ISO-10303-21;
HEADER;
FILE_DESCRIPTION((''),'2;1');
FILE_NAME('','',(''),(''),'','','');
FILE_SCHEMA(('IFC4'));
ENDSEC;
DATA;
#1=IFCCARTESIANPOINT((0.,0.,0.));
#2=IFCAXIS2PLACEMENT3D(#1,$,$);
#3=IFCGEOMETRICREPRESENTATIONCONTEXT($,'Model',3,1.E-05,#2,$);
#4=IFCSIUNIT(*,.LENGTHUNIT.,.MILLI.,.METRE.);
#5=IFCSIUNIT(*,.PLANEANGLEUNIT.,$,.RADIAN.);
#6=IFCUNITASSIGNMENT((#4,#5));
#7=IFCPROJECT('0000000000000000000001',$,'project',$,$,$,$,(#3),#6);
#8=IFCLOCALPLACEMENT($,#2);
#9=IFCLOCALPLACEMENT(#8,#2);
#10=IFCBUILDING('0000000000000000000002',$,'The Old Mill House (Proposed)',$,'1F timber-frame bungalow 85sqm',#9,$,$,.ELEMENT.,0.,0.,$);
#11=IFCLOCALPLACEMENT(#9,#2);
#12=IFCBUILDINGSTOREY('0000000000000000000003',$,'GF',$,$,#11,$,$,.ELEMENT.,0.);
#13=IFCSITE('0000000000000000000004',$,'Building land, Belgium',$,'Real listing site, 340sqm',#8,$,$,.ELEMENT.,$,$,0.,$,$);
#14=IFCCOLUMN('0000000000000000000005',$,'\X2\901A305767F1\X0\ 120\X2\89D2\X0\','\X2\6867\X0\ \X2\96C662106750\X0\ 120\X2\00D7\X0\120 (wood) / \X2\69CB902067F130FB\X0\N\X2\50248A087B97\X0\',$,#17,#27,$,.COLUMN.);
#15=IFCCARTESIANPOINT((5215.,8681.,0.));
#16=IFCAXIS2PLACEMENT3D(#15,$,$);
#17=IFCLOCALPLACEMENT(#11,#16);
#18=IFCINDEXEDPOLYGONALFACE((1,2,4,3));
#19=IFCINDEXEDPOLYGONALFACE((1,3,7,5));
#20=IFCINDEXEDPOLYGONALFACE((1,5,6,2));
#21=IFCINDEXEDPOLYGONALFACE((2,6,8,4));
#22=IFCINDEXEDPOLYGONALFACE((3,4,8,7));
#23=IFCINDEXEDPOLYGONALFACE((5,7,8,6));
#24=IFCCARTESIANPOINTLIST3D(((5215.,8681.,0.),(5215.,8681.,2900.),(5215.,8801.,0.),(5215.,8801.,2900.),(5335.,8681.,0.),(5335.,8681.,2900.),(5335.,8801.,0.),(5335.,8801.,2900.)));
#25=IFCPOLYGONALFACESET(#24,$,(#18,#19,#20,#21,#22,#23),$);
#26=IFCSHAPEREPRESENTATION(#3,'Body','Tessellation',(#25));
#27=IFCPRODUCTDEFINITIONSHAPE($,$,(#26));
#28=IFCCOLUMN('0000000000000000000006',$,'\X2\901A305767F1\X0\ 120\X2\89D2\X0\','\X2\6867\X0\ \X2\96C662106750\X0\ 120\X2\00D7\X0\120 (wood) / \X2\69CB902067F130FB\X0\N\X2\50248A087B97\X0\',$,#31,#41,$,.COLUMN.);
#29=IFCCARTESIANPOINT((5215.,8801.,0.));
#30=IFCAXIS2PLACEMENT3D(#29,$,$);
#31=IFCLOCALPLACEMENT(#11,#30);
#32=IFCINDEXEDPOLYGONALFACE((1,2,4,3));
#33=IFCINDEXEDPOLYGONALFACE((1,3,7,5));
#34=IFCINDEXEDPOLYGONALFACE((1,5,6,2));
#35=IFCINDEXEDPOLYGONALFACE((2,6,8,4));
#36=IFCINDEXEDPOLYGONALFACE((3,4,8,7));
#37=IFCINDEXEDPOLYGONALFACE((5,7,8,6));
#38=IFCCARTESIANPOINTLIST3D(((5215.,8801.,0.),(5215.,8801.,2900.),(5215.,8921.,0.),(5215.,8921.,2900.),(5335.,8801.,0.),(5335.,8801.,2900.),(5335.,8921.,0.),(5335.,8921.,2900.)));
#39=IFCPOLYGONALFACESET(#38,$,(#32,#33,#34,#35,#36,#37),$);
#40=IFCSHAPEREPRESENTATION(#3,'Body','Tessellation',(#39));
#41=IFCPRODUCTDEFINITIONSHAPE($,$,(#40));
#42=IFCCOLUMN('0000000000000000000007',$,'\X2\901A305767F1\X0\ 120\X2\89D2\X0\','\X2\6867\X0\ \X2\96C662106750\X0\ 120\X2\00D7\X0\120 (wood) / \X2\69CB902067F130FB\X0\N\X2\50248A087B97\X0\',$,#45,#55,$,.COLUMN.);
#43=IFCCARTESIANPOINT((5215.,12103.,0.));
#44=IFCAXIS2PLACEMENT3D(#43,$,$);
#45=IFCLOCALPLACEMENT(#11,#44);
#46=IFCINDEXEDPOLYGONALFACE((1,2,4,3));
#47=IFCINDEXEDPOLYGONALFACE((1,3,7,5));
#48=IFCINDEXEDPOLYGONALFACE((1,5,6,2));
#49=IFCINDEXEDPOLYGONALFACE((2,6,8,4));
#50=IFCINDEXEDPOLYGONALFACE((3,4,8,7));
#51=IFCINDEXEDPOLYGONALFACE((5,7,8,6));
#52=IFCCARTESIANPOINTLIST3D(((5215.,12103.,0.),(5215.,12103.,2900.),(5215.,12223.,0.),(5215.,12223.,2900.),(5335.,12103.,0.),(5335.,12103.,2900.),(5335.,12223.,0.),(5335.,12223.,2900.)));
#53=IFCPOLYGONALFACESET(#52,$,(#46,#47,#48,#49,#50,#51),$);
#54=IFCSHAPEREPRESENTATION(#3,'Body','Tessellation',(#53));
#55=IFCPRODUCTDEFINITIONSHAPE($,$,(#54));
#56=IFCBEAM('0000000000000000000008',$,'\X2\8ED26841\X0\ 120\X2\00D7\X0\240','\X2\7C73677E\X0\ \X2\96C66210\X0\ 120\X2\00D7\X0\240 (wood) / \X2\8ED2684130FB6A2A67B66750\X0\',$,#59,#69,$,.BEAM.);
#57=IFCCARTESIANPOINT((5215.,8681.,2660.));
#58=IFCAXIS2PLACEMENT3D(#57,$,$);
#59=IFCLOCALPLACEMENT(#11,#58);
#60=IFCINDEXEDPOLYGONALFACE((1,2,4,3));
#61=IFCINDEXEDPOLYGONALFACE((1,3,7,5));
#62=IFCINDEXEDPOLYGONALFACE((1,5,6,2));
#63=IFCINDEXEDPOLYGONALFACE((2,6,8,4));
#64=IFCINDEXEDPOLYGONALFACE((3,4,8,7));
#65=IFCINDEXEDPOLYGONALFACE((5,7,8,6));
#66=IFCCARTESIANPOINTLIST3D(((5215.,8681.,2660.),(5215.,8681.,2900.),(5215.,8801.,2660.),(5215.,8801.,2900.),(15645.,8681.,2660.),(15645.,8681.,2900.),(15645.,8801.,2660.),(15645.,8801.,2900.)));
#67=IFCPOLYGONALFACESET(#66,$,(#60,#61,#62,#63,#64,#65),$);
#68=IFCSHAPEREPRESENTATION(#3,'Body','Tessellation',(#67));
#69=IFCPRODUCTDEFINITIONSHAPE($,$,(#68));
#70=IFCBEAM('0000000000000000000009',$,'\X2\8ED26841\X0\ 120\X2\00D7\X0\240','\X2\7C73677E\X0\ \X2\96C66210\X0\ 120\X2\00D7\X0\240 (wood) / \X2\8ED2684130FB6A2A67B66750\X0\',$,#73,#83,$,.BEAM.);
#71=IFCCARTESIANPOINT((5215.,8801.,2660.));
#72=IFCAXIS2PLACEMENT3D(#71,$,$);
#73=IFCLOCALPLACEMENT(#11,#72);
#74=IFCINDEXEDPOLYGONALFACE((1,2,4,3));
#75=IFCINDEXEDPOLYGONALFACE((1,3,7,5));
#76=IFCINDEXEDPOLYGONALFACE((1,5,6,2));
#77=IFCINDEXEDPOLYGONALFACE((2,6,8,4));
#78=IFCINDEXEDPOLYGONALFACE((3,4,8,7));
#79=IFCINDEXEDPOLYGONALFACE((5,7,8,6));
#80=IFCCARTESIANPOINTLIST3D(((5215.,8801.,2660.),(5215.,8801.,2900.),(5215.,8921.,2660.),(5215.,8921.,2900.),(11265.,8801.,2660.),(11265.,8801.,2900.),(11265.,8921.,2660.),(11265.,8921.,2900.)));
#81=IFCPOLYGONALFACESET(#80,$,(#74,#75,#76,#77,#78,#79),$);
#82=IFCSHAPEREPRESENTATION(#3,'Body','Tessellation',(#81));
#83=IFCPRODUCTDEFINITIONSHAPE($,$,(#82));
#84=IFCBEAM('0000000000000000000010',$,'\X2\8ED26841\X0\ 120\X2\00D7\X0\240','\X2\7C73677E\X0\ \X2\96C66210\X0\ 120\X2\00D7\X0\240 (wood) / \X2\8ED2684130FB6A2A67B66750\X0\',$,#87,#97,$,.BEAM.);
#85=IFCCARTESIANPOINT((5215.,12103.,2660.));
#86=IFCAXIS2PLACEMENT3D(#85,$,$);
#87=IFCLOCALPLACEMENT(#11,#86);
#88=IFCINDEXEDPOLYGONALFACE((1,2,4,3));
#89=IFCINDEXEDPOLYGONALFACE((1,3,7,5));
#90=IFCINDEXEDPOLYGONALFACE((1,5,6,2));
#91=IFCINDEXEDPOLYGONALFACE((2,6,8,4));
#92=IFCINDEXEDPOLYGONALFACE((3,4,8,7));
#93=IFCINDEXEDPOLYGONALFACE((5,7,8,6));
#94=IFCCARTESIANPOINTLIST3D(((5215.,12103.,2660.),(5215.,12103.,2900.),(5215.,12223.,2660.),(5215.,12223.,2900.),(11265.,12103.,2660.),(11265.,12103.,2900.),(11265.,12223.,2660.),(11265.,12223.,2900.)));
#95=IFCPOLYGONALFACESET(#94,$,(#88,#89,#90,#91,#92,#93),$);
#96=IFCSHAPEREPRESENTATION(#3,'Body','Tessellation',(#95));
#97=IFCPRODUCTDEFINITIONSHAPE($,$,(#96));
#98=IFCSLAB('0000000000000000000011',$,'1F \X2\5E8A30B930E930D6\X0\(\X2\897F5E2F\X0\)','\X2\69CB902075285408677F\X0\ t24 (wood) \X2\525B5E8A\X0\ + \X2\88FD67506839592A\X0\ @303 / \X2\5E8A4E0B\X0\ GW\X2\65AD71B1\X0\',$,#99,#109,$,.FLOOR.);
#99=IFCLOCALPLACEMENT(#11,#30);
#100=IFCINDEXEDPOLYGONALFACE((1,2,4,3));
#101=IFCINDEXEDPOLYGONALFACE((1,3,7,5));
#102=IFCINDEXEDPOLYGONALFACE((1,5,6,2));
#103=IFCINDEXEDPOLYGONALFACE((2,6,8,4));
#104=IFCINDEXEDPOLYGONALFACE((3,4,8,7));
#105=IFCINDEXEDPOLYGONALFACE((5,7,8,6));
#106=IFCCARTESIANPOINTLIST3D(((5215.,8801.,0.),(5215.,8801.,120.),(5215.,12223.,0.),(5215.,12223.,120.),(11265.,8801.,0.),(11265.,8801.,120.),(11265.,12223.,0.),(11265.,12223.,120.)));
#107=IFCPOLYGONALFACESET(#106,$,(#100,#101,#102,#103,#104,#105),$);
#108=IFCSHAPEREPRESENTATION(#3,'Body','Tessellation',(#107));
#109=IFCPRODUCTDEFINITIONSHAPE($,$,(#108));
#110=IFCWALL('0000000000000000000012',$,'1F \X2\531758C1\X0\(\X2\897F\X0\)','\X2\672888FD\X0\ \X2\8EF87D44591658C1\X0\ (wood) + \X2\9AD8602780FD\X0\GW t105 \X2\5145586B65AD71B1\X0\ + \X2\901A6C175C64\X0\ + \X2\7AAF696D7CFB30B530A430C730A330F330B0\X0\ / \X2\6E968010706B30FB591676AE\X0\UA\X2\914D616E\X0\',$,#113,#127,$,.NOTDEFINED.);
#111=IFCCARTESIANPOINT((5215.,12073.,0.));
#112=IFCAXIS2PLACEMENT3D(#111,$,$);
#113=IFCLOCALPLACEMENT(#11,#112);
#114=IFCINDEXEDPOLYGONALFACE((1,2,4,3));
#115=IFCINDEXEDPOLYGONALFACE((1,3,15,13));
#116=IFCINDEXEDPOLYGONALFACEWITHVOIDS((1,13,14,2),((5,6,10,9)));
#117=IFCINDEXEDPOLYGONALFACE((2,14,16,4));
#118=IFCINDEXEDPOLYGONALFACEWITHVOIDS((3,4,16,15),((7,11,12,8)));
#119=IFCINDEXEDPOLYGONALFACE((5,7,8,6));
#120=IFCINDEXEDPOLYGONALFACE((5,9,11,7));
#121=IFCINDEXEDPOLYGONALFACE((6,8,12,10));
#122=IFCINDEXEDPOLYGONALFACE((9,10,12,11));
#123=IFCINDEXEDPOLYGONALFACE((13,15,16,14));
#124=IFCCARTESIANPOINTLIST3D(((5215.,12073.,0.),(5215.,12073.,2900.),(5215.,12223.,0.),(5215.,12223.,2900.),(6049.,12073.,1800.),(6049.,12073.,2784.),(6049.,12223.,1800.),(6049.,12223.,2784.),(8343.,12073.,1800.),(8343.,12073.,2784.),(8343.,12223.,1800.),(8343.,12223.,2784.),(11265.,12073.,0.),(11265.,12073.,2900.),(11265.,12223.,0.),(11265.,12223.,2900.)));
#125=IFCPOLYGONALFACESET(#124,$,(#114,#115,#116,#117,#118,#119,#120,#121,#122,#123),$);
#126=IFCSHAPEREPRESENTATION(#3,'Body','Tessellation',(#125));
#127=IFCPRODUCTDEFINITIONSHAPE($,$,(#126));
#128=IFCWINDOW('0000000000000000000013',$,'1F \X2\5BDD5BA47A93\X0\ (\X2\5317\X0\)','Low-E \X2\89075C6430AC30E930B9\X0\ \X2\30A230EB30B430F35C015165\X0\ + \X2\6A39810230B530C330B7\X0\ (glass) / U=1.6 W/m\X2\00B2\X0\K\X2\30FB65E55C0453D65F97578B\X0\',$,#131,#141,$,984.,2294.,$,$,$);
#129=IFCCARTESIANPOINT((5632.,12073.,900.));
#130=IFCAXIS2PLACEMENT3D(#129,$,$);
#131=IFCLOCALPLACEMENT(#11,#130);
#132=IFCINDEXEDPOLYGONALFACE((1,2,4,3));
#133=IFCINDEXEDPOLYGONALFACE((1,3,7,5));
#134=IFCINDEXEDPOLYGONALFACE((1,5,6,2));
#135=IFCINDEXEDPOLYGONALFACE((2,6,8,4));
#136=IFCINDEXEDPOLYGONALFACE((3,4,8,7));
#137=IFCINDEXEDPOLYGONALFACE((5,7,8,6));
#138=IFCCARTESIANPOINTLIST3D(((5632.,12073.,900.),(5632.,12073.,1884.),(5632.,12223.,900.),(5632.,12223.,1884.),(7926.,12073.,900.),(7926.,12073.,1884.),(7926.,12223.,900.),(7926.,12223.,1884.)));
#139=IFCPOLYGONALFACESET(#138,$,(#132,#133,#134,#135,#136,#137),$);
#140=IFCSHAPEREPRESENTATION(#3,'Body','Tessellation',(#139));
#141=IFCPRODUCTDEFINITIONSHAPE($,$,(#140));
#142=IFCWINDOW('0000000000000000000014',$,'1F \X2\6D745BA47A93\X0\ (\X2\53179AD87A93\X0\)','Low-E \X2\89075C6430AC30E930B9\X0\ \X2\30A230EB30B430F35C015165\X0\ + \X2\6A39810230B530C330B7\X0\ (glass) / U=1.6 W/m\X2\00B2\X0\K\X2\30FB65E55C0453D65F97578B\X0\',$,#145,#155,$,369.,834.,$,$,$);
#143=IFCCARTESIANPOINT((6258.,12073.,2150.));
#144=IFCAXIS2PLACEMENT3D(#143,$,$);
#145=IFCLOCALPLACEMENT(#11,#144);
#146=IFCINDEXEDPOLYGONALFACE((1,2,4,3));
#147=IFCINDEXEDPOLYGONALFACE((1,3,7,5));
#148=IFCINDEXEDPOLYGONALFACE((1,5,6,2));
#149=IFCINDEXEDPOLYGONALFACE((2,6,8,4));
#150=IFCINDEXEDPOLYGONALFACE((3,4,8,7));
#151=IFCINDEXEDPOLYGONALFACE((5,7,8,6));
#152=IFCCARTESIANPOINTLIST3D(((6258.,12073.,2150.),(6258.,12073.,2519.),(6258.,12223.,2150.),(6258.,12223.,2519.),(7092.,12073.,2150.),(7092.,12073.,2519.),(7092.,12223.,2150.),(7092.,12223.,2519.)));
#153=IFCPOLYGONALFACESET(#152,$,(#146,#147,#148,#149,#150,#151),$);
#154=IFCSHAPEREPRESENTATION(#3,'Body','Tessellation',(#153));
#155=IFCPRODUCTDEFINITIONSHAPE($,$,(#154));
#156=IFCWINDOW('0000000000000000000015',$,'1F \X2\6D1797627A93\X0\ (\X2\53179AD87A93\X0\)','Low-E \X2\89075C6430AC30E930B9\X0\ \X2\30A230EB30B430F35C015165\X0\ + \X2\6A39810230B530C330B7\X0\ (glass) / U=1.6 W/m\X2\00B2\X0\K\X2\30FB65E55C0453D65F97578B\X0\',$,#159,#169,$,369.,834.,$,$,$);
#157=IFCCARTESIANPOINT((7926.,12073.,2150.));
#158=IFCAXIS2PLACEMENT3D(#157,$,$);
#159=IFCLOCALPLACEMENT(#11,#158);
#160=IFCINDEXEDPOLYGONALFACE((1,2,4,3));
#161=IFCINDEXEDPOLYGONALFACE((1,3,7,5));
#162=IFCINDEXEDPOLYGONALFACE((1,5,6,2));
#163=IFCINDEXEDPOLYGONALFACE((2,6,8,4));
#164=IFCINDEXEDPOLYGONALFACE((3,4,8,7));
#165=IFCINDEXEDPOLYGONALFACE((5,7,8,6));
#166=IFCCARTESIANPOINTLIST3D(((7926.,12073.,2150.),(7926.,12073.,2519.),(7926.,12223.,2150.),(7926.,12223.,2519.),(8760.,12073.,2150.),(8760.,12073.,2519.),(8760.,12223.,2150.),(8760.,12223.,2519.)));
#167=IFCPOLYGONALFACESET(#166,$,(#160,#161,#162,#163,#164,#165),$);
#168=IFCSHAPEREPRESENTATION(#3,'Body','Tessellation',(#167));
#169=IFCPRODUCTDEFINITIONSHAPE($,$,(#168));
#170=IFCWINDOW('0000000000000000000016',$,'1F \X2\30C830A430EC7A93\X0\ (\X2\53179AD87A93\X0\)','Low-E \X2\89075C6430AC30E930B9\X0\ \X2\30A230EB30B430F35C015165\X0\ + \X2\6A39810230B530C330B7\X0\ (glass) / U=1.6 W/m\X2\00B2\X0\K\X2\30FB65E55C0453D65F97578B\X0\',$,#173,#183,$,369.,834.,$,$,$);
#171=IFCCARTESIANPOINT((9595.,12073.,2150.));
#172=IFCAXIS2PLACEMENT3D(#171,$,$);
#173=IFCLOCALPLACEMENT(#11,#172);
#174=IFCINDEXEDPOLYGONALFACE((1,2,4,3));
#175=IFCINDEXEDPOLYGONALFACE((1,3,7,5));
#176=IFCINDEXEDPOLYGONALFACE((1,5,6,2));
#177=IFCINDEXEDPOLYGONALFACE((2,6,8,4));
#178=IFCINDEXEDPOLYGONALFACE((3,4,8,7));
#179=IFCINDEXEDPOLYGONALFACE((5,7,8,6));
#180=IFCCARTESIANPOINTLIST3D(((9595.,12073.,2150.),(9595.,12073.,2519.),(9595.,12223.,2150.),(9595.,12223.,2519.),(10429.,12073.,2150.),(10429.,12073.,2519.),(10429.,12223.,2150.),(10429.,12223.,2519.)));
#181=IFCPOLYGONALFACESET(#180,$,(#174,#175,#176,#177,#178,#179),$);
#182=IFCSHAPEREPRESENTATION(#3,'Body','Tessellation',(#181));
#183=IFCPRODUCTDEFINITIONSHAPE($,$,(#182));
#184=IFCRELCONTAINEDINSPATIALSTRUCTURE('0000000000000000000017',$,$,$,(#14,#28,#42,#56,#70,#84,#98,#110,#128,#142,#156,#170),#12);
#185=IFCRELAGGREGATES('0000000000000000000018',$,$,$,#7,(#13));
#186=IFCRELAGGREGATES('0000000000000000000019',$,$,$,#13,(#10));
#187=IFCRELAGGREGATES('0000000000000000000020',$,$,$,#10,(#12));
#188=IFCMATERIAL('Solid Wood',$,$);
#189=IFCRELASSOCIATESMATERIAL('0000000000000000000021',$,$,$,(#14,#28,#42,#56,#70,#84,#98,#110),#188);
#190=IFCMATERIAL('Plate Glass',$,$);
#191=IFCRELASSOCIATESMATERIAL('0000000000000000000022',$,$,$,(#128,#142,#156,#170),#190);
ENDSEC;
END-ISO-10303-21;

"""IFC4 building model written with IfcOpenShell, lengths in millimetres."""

from ifc_helpers import new_model, si_unit, frame, frame_2d, origin, place, context, project, spatial, rectangle, extrude, material, element, fill, save


model = new_model("IFC4")

# Units and contexts
model_context = context("Model", 3, precision=1e-05, world=origin())
ifc_project = project(units=[si_unit("LENGTHUNIT", "METRE", prefix="MILLI"), si_unit("PLANEANGLEUNIT", "RADIAN")], contexts=[model_context])

# Site, building, storey
site_placement = place(None, origin())
site = spatial("IfcSite", under=ifc_project, at=site_placement, Name="Building land, Belgium", ObjectType="Real listing site, 340sqm", CompositionType="ELEMENT", RefElevation=0.0)
building_placement = place(site_placement, origin())
building = spatial("IfcBuilding", under=site, at=building_placement, Name="The Old Mill House (Proposed)", ObjectType="1F timber-frame bungalow 85sqm", CompositionType="ELEMENT", ElevationOfRefHeight=0.0, ElevationOfTerrain=0.0)
storey_placement = place(building_placement, origin())
storey = spatial("IfcBuildingStorey", under=building, at=storey_placement, Name="GF", CompositionType="ELEMENT", Elevation=0.0)

# Columns
ifc_material_1 = material(Name="Solid Wood")
column_1_placement = place(storey_placement, frame((5215.0, 8681.0, 0.0)))
element("IfcColumn", 1, at=column_1_placement, inside=storey, material=ifc_material_1, Name="通し柱 120角", Description="桧 集成材 120×120 (wood) / 構造柱・N値計算", PredefinedType="COLUMN", context=model_context, shape_type="SweptSolid", body=[
    extrude(rectangle(XDim=120.0, YDim=120.0, at=frame_2d((60.0, 60.0))), frame((5215.0, 8681.0, 0.0)), (0.0, 0.0, 1.0), 2900.0),
])
column_2_placement = place(storey_placement, frame((5215.0, 8801.0, 0.0)))
element("IfcColumn", 2, at=column_2_placement, inside=storey, material=ifc_material_1, Name="通し柱 120角", Description="桧 集成材 120×120 (wood) / 構造柱・N値計算", PredefinedType="COLUMN", context=model_context, shape_type="SweptSolid", body=[
    extrude(rectangle(XDim=120.0, YDim=120.0, at=frame_2d((60.0, 60.0))), frame((5215.0, 8801.0, 0.0)), (0.0, 0.0, 1.0), 2900.0),
])
column_3_placement = place(storey_placement, frame((5215.0, 12103.0, 0.0)))
element("IfcColumn", 3, at=column_3_placement, inside=storey, material=ifc_material_1, Name="通し柱 120角", Description="桧 集成材 120×120 (wood) / 構造柱・N値計算", PredefinedType="COLUMN", context=model_context, shape_type="SweptSolid", body=[
    extrude(rectangle(XDim=120.0, YDim=120.0, at=frame_2d((60.0, 60.0))), frame((5215.0, 12103.0, 0.0)), (0.0, 0.0, 1.0), 2900.0),
])

# Beams
beam_1_placement = place(storey_placement, frame((5215.0, 8681.0, 2660.0)))
element("IfcBeam", 4, at=beam_1_placement, inside=storey, material=ifc_material_1, Name="軒桁 120×240", Description="米松 集成 120×240 (wood) / 軒桁・横架材", PredefinedType="BEAM", context=model_context, shape_type="SweptSolid", body=[
    extrude(rectangle(XDim=10430.0, YDim=120.0, at=frame_2d((5215.0, 60.0))), frame((5215.0, 8681.0, 2660.0)), (0.0, 0.0, 1.0), 240.0),
])
beam_2_placement = place(storey_placement, frame((5215.0, 8801.0, 2660.0)))
element("IfcBeam", 5, at=beam_2_placement, inside=storey, material=ifc_material_1, Name="軒桁 120×240", Description="米松 集成 120×240 (wood) / 軒桁・横架材", PredefinedType="BEAM", context=model_context, shape_type="SweptSolid", body=[
    extrude(rectangle(XDim=6050.0, YDim=120.0, at=frame_2d((3025.0, 60.0))), frame((5215.0, 8801.0, 2660.0)), (0.0, 0.0, 1.0), 240.0),
])
beam_3_placement = place(storey_placement, frame((5215.0, 12103.0, 2660.0)))
element("IfcBeam", 6, at=beam_3_placement, inside=storey, material=ifc_material_1, Name="軒桁 120×240", Description="米松 集成 120×240 (wood) / 軒桁・横架材", PredefinedType="BEAM", context=model_context, shape_type="SweptSolid", body=[
    extrude(rectangle(XDim=6050.0, YDim=120.0, at=frame_2d((3025.0, 60.0))), frame((5215.0, 12103.0, 2660.0)), (0.0, 0.0, 1.0), 240.0),
])

# Slab
slab_placement = place(storey_placement, frame((5215.0, 8801.0, 0.0)))
element("IfcSlab", 7, at=slab_placement, inside=storey, material=ifc_material_1, Name="1F 床スラブ(西帯)", Description="構造用合板 t24 (wood) 剛床 + 製材根太 @303 / 床下 GW断熱", PredefinedType="FLOOR", context=model_context, shape_type="SweptSolid", body=[
    extrude(rectangle(XDim=6050.0, YDim=3422.0, at=frame_2d((3025.0, 1711.0))), frame((5215.0, 8801.0, 0.0)), (0.0, 0.0, 1.0), 120.0),
])

# Wall, openings, windows
wall_1_placement = place(storey_placement, frame((5215.0, 12073.0, 0.0)))
wall_1 = element("IfcWall", 8, at=wall_1_placement, inside=storey, material=ifc_material_1, Name="1F 北壁(西)", Description="木製 軸組外壁 (wood) + 高性能GW t105 充填断熱 + 通気層 + 窯業系サイディング / 準耐火・外皮UA配慮", PredefinedType="NOTDEFINED", context=model_context, shape_type="SweptSolid", body=[
    extrude(rectangle(XDim=6050.0, YDim=150.0, at=frame_2d((3025.0, 75.0))), frame((5215.0, 12073.0, 0.0)), (0.0, 0.0, 1.0), 2900.0),
])
opening_1_placement = place(storey_placement, frame((5632.0, 12073.0, 900.0)))
opening_1 = element("IfcOpeningElement", 9, at=opening_1_placement, cuts=wall_1, PredefinedType="NOTDEFINED", context=model_context, shape_type="SweptSolid", body=[
    extrude(rectangle(XDim=2294.0, YDim=150.0, at=frame_2d((1147.0, 75.0))), frame((5632.0, 12073.0, 900.0)), (0.0, 0.0, 1.0), 984.0),
])
opening_2_placement = place(storey_placement, frame((6258.0, 12073.0, 2150.0)))
opening_2 = element("IfcOpeningElement", 10, at=opening_2_placement, cuts=wall_1, PredefinedType="NOTDEFINED", context=model_context, shape_type="SweptSolid", body=[
    extrude(rectangle(XDim=834.0, YDim=150.0, at=frame_2d((417.0, 75.0))), frame((6258.0, 12073.0, 2150.0)), (0.0, 0.0, 1.0), 369.0),
])
opening_3_placement = place(storey_placement, frame((7926.0, 12073.0, 2150.0)))
opening_3 = element("IfcOpeningElement", 11, at=opening_3_placement, cuts=wall_1, PredefinedType="NOTDEFINED", context=model_context, shape_type="SweptSolid", body=[
    extrude(rectangle(XDim=834.0, YDim=150.0, at=frame_2d((417.0, 75.0))), frame((7926.0, 12073.0, 2150.0)), (0.0, 0.0, 1.0), 369.0),
])
opening_4_placement = place(storey_placement, frame((9595.0, 12073.0, 2150.0)))
opening_4 = element("IfcOpeningElement", 12, at=opening_4_placement, cuts=wall_1, PredefinedType="NOTDEFINED", context=model_context, shape_type="SweptSolid", body=[
    extrude(rectangle(XDim=834.0, YDim=150.0, at=frame_2d((417.0, 75.0))), frame((9595.0, 12073.0, 2150.0)), (0.0, 0.0, 1.0), 369.0),
])
ifc_material_2 = material(Name="Plate Glass")
window_1_placement = place(storey_placement, frame((5632.0, 12073.0, 900.0)))
window_1 = element("IfcWindow", 13, at=window_1_placement, inside=storey, material=ifc_material_2, Name="1F 寝室窓 (北)", Description="Low-E 複層ガラス アルゴン封入 + 樹脂サッシ (glass) / U=1.6 W/m²K・日射取得型", OverallHeight=984.0, OverallWidth=2294.0, context=model_context, shape_type="SweptSolid", body=[
    extrude(rectangle(XDim=2294.0, YDim=150.0, at=frame_2d((1147.0, 75.0))), frame((5632.0, 12073.0, 900.0)), (0.0, 0.0, 1.0), 984.0),
])
fill(opening_1, window_1)
window_2_placement = place(storey_placement, frame((6258.0, 12073.0, 2150.0)))
window_2 = element("IfcWindow", 14, at=window_2_placement, inside=storey, material=ifc_material_2, Name="1F 浴室窓 (北高窓)", Description="Low-E 複層ガラス アルゴン封入 + 樹脂サッシ (glass) / U=1.6 W/m²K・日射取得型", OverallHeight=369.0, OverallWidth=834.0, context=model_context, shape_type="SweptSolid", body=[
    extrude(rectangle(XDim=834.0, YDim=150.0, at=frame_2d((417.0, 75.0))), frame((6258.0, 12073.0, 2150.0)), (0.0, 0.0, 1.0), 369.0),
])
fill(opening_2, window_2)
window_3_placement = place(storey_placement, frame((7926.0, 12073.0, 2150.0)))
window_3 = element("IfcWindow", 15, at=window_3_placement, inside=storey, material=ifc_material_2, Name="1F 洗面窓 (北高窓)", Description="Low-E 複層ガラス アルゴン封入 + 樹脂サッシ (glass) / U=1.6 W/m²K・日射取得型", OverallHeight=369.0, OverallWidth=834.0, context=model_context, shape_type="SweptSolid", body=[
    extrude(rectangle(XDim=834.0, YDim=150.0, at=frame_2d((417.0, 75.0))), frame((7926.0, 12073.0, 2150.0)), (0.0, 0.0, 1.0), 369.0),
])
fill(opening_3, window_3)
window_4_placement = place(storey_placement, frame((9595.0, 12073.0, 2150.0)))
window_4 = element("IfcWindow", 16, at=window_4_placement, inside=storey, material=ifc_material_2, Name="1F トイレ窓 (北高窓)", Description="Low-E 複層ガラス アルゴン封入 + 樹脂サッシ (glass) / U=1.6 W/m²K・日射取得型", OverallHeight=369.0, OverallWidth=834.0, context=model_context, shape_type="SweptSolid", body=[
    extrude(rectangle(XDim=834.0, YDim=150.0, at=frame_2d((417.0, 75.0))), frame((9595.0, 12073.0, 2150.0)), (0.0, 0.0, 1.0), 369.0),
])
fill(opening_4, window_4)

save(model, "model.ifc")
